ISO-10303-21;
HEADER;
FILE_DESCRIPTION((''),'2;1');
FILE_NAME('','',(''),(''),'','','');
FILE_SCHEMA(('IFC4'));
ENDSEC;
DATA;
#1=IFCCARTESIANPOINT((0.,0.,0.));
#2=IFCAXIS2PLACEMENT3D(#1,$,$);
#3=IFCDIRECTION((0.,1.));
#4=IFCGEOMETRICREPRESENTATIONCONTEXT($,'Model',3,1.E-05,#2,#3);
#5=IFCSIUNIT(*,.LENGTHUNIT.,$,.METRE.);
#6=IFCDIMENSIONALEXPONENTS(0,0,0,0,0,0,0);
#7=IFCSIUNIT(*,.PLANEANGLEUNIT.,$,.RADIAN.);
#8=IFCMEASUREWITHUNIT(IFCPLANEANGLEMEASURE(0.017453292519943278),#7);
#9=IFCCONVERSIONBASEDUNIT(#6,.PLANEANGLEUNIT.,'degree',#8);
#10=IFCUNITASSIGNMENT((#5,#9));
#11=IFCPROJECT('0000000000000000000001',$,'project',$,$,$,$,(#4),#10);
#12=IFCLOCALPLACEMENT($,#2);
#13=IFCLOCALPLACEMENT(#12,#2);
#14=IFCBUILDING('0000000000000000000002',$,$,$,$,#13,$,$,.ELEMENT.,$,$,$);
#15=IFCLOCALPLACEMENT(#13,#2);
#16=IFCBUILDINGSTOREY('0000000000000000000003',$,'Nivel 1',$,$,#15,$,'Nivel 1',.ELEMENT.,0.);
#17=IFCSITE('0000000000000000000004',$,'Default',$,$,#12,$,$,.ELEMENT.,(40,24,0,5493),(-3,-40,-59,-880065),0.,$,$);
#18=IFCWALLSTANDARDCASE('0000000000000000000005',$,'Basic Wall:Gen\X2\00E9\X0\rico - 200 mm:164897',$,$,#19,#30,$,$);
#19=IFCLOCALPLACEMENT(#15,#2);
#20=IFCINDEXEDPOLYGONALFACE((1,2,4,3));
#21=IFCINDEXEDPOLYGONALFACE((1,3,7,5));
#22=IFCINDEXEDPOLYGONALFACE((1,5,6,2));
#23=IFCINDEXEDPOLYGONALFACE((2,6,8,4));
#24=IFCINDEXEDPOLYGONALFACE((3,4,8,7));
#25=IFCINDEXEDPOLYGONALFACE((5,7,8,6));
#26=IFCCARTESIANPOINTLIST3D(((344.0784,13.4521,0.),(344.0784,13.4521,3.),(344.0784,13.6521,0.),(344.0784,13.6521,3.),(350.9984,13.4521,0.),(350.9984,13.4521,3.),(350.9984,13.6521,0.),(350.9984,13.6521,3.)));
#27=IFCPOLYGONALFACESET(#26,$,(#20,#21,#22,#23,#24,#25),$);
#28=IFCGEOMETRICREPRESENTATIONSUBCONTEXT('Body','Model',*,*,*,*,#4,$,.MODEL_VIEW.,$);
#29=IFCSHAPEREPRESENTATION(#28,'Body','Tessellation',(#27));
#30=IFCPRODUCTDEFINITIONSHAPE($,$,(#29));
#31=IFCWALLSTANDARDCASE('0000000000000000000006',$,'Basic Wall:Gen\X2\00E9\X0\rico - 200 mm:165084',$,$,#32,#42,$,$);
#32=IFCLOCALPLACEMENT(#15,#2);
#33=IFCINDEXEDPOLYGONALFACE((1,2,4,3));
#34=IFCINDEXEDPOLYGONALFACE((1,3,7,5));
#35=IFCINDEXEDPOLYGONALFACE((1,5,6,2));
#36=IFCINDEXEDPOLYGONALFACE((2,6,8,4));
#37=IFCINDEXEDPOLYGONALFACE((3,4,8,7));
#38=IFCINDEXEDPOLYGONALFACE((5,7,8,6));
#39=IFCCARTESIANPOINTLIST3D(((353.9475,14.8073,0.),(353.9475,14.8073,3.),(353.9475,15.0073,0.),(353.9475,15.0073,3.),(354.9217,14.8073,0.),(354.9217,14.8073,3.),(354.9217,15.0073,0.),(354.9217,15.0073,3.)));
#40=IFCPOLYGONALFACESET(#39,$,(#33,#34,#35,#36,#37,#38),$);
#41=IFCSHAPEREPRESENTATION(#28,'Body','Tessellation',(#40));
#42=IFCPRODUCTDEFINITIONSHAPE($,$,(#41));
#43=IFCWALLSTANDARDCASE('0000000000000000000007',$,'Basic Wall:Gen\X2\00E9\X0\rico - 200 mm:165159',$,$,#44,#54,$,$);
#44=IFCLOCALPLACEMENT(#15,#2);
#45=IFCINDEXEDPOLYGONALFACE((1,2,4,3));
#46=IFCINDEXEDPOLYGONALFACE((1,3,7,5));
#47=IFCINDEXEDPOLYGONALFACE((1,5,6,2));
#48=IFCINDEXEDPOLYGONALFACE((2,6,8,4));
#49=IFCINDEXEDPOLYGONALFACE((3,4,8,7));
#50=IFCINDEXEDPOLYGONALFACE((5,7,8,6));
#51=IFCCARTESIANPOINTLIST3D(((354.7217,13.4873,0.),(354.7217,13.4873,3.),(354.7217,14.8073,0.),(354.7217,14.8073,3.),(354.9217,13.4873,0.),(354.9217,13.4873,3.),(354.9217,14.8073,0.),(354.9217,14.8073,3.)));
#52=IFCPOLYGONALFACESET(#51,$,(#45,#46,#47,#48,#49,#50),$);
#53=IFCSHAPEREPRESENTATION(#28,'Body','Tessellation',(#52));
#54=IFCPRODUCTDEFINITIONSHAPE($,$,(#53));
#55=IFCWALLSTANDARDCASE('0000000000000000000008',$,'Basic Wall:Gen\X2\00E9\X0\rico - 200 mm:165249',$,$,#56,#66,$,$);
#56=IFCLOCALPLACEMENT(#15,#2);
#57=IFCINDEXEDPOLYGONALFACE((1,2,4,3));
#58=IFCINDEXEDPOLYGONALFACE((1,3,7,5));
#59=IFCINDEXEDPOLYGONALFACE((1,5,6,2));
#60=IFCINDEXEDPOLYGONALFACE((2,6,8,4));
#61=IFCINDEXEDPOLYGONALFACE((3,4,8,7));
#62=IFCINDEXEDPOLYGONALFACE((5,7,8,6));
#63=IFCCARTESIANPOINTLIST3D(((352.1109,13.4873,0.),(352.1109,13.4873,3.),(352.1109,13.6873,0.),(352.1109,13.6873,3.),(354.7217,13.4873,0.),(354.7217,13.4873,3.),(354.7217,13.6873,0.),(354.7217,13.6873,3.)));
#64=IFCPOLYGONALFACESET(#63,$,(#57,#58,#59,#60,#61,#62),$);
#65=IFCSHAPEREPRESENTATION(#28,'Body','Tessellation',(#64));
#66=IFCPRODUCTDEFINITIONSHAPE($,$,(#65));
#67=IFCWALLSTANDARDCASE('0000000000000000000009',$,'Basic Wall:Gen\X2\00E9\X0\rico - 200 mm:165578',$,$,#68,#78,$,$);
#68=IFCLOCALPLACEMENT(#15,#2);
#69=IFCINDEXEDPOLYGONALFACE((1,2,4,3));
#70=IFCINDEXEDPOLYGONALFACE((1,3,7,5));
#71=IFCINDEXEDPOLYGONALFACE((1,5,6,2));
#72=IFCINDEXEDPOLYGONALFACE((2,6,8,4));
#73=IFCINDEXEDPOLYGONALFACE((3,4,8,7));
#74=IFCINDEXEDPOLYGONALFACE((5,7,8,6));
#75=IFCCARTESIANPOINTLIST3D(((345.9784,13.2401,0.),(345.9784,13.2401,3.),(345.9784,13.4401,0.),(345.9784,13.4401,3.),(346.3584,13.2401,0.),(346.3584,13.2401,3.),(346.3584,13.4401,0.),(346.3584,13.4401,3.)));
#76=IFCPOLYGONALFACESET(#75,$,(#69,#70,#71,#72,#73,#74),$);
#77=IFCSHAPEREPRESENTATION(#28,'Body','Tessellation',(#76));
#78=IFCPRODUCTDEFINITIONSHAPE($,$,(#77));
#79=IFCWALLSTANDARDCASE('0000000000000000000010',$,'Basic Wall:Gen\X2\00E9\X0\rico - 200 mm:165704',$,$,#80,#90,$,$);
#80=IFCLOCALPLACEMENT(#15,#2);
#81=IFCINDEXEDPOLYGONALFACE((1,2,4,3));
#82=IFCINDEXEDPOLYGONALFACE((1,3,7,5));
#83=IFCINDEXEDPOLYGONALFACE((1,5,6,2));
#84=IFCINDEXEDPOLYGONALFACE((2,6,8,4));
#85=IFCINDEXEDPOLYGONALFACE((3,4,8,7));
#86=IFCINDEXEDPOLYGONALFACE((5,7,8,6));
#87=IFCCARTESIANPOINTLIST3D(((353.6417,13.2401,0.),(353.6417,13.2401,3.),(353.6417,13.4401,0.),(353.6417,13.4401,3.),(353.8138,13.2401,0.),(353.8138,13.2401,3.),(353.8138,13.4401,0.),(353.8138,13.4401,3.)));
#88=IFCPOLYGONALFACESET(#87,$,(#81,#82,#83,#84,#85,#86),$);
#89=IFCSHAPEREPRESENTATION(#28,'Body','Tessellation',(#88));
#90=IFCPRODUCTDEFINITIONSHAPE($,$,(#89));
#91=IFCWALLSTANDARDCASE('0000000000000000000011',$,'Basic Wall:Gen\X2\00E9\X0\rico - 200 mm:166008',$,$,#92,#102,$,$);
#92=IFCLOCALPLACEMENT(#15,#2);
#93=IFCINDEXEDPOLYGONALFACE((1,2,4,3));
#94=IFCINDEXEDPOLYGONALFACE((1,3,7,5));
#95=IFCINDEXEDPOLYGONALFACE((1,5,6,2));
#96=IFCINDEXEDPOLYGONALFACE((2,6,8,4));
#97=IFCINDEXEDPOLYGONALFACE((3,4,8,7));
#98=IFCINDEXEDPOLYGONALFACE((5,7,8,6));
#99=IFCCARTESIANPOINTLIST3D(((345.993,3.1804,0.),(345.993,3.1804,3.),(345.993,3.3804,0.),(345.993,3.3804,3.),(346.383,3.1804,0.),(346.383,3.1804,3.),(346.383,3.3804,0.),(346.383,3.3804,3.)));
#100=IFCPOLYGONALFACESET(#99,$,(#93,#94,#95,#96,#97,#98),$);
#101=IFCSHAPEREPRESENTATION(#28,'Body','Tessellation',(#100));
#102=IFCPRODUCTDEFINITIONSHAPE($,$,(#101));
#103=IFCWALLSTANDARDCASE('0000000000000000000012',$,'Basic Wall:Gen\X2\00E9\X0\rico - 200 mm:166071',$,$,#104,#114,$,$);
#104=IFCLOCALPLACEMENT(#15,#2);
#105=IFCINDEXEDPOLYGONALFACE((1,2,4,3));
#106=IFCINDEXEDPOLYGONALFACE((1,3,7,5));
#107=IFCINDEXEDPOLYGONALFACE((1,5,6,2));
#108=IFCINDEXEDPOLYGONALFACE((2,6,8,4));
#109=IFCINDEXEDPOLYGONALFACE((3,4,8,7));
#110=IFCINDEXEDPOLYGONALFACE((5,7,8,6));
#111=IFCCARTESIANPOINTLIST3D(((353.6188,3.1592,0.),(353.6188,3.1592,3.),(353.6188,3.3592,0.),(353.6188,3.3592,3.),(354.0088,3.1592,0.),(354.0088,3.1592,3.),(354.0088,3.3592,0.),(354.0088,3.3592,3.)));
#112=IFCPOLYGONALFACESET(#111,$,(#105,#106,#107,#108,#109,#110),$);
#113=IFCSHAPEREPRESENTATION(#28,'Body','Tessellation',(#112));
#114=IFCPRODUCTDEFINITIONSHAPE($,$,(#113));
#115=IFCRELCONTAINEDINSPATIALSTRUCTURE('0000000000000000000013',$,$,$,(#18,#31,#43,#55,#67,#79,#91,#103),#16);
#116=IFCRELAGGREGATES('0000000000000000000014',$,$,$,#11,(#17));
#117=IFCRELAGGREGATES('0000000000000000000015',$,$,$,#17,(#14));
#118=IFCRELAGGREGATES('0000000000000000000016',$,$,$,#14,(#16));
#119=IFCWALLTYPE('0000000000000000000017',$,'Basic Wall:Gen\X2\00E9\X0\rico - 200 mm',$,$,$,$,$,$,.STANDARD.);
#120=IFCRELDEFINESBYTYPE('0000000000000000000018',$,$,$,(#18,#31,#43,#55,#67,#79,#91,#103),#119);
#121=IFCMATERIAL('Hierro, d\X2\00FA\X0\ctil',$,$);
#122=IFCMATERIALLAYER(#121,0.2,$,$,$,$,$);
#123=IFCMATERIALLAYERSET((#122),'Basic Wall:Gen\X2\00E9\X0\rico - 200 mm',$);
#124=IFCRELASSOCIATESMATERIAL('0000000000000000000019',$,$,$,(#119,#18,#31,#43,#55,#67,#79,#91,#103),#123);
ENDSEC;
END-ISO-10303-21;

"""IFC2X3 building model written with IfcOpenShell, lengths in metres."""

from ifc_helpers import new_model, entity, si_unit, converted_unit, direction, frame, frame_2d, origin, place, context, subcontext, project, spatial, rectangle, extrude, material, layer, layer_set, layer_usage, type_object, element, save


model = new_model("IFC2X3")

# Units and contexts
model_context = context("Model", 3, precision=1e-05, world=origin(), true_north=direction((0.0, 1.0)))
body_context = subcontext(model_context, "Body", "Model", "MODEL_VIEW")
ifc_project = project(units=[si_unit("LENGTHUNIT", "METRE"), converted_unit("PLANEANGLEUNIT", "degree", entity("IfcPlaneAngleMeasure", 0.017453292519943278), si_unit("PLANEANGLEUNIT", "RADIAN"), dimensions=[0, 0, 0, 0, 0, 0, 0])], contexts=[model_context])

# Site, building, storey
site_placement = place(None, origin())
site = spatial("IfcSite", under=ifc_project, at=site_placement, Name="Default", CompositionType="ELEMENT", RefLatitude=(40, 24, 0, 5493), RefLongitude=(-3, -40, -59, -880065), RefElevation=0.0)
building_placement = place(site_placement, origin())
building = spatial("IfcBuilding", under=site, at=building_placement, CompositionType="ELEMENT")
storey_placement = place(building_placement, origin())
storey = spatial("IfcBuildingStorey", under=building, at=storey_placement, Name="Nivel 1", LongName="Nivel 1", CompositionType="ELEMENT", Elevation=0.0)

# Walls
ifc_material_1 = material(Name="Hierro, dúctil")
ifc_layer_1 = layer(ifc_material_1, 0.2)
ifc_layer_set_1 = layer_set([ifc_layer_1], Name="Basic Wall:Genérico - 200 mm")
wall_type = type_object("IfcWallType", Name="Basic Wall:Genérico - 200 mm", PredefinedType="STANDARD", material=ifc_layer_set_1)
ifc_layer_usage_1 = layer_usage(ifc_layer_set_1, "AXIS2", "NEGATIVE", 0.1)
wall_1_placement = place(storey_placement, frame((344.0784, 13.5521, 0.0)))
element("IfcWallStandardCase", 1, at=wall_1_placement, inside=storey, type_object=wall_type, material=ifc_layer_usage_1, Name="Basic Wall:Genérico - 200 mm:164897", context=body_context, shape_type="SweptSolid", body=[
    extrude(rectangle(XDim=6.92, YDim=0.2, at=frame_2d((3.46, 0.0), x_axis=(-1.0, 0.0))), origin(), (0.0, 0.0, 1.0), 3.0),
])
ifc_layer_usage_2 = layer_usage(ifc_layer_set_1, "AXIS2", "NEGATIVE", 0.1)
wall_2_placement = place(storey_placement, frame((353.9475, 14.9073, 0.0)))
element("IfcWallStandardCase", 2, at=wall_2_placement, inside=storey, type_object=wall_type, material=ifc_layer_usage_2, Name="Basic Wall:Genérico - 200 mm:165084", context=body_context, shape_type="SweptSolid", body=[
    extrude(rectangle(XDim=0.9742, YDim=0.2, at=frame_2d((0.4871, 0.0), x_axis=(-1.0, 0.0))), origin(), (0.0, 0.0, 1.0), 3.0),
])
ifc_layer_usage_3 = layer_usage(ifc_layer_set_1, "AXIS2", "NEGATIVE", 0.1)
wall_3_placement = place(storey_placement, frame((354.8217, 14.8073, 0.0), z_axis=(0.0, 0.0, 1.0), x_axis=(0.0, -1.0, 0.0)))
element("IfcWallStandardCase", 3, at=wall_3_placement, inside=storey, type_object=wall_type, material=ifc_layer_usage_3, Name="Basic Wall:Genérico - 200 mm:165159", context=body_context, shape_type="SweptSolid", body=[
    extrude(rectangle(XDim=1.32, YDim=0.2, at=frame_2d((0.66, 0.0), x_axis=(-1.0, 0.0))), origin(), (0.0, 0.0, 1.0), 3.0),
])
ifc_layer_usage_4 = layer_usage(ifc_layer_set_1, "AXIS2", "NEGATIVE", 0.1)
wall_4_placement = place(storey_placement, frame((354.7217, 13.5873, 0.0), z_axis=(0.0, 0.0, 1.0), x_axis=(-1.0, 0.0, 0.0)))
element("IfcWallStandardCase", 4, at=wall_4_placement, inside=storey, type_object=wall_type, material=ifc_layer_usage_4, Name="Basic Wall:Genérico - 200 mm:165249", context=body_context, shape_type="SweptSolid", body=[
    extrude(rectangle(XDim=2.6108, YDim=0.2, at=frame_2d((1.3054, 0.0), x_axis=(-1.0, 0.0))), origin(), (0.0, 0.0, 1.0), 3.0),
])
ifc_layer_usage_5 = layer_usage(ifc_layer_set_1, "AXIS2", "NEGATIVE", 0.1)
wall_5_placement = place(storey_placement, frame((345.9784, 13.3401, 0.0)))
element("IfcWallStandardCase", 5, at=wall_5_placement, inside=storey, type_object=wall_type, material=ifc_layer_usage_5, Name="Basic Wall:Genérico - 200 mm:165578", context=body_context, shape_type="SweptSolid", body=[
    extrude(rectangle(XDim=0.38, YDim=0.2, at=frame_2d((0.19, 0.0), x_axis=(-1.0, 0.0))), origin(), (0.0, 0.0, 1.0), 3.0),
])
ifc_layer_usage_6 = layer_usage(ifc_layer_set_1, "AXIS2", "NEGATIVE", 0.1)
wall_6_placement = place(storey_placement, frame((353.6417, 13.3401, 0.0)))
element("IfcWallStandardCase", 6, at=wall_6_placement, inside=storey, type_object=wall_type, material=ifc_layer_usage_6, Name="Basic Wall:Genérico - 200 mm:165704", context=body_context, shape_type="SweptSolid", body=[
    extrude(rectangle(XDim=0.172, YDim=0.2, at=frame_2d((0.086, 0.0), x_axis=(-1.0, 0.0))), origin(), (0.0, 0.0, 1.0), 3.0),
])
ifc_layer_usage_7 = layer_usage(ifc_layer_set_1, "AXIS2", "NEGATIVE", 0.1)
wall_7_placement = place(storey_placement, frame((345.993, 3.2804, 0.0)))
element("IfcWallStandardCase", 7, at=wall_7_placement, inside=storey, type_object=wall_type, material=ifc_layer_usage_7, Name="Basic Wall:Genérico - 200 mm:166008", context=body_context, shape_type="SweptSolid", body=[
    extrude(rectangle(XDim=0.39, YDim=0.2, at=frame_2d((0.195, 0.0), x_axis=(-1.0, 0.0))), origin(), (0.0, 0.0, 1.0), 3.0),
])
ifc_layer_usage_8 = layer_usage(ifc_layer_set_1, "AXIS2", "NEGATIVE", 0.1)
wall_8_placement = place(storey_placement, frame((353.6188, 3.2592, 0.0)))
element("IfcWallStandardCase", 8, at=wall_8_placement, inside=storey, type_object=wall_type, material=ifc_layer_usage_8, Name="Basic Wall:Genérico - 200 mm:166071", context=body_context, shape_type="SweptSolid", body=[
    extrude(rectangle(XDim=0.39, YDim=0.2, at=frame_2d((0.195, 0.0), x_axis=(-1.0, 0.0))), origin(), (0.0, 0.0, 1.0), 3.0),
])

save(model, "model.ifc")
